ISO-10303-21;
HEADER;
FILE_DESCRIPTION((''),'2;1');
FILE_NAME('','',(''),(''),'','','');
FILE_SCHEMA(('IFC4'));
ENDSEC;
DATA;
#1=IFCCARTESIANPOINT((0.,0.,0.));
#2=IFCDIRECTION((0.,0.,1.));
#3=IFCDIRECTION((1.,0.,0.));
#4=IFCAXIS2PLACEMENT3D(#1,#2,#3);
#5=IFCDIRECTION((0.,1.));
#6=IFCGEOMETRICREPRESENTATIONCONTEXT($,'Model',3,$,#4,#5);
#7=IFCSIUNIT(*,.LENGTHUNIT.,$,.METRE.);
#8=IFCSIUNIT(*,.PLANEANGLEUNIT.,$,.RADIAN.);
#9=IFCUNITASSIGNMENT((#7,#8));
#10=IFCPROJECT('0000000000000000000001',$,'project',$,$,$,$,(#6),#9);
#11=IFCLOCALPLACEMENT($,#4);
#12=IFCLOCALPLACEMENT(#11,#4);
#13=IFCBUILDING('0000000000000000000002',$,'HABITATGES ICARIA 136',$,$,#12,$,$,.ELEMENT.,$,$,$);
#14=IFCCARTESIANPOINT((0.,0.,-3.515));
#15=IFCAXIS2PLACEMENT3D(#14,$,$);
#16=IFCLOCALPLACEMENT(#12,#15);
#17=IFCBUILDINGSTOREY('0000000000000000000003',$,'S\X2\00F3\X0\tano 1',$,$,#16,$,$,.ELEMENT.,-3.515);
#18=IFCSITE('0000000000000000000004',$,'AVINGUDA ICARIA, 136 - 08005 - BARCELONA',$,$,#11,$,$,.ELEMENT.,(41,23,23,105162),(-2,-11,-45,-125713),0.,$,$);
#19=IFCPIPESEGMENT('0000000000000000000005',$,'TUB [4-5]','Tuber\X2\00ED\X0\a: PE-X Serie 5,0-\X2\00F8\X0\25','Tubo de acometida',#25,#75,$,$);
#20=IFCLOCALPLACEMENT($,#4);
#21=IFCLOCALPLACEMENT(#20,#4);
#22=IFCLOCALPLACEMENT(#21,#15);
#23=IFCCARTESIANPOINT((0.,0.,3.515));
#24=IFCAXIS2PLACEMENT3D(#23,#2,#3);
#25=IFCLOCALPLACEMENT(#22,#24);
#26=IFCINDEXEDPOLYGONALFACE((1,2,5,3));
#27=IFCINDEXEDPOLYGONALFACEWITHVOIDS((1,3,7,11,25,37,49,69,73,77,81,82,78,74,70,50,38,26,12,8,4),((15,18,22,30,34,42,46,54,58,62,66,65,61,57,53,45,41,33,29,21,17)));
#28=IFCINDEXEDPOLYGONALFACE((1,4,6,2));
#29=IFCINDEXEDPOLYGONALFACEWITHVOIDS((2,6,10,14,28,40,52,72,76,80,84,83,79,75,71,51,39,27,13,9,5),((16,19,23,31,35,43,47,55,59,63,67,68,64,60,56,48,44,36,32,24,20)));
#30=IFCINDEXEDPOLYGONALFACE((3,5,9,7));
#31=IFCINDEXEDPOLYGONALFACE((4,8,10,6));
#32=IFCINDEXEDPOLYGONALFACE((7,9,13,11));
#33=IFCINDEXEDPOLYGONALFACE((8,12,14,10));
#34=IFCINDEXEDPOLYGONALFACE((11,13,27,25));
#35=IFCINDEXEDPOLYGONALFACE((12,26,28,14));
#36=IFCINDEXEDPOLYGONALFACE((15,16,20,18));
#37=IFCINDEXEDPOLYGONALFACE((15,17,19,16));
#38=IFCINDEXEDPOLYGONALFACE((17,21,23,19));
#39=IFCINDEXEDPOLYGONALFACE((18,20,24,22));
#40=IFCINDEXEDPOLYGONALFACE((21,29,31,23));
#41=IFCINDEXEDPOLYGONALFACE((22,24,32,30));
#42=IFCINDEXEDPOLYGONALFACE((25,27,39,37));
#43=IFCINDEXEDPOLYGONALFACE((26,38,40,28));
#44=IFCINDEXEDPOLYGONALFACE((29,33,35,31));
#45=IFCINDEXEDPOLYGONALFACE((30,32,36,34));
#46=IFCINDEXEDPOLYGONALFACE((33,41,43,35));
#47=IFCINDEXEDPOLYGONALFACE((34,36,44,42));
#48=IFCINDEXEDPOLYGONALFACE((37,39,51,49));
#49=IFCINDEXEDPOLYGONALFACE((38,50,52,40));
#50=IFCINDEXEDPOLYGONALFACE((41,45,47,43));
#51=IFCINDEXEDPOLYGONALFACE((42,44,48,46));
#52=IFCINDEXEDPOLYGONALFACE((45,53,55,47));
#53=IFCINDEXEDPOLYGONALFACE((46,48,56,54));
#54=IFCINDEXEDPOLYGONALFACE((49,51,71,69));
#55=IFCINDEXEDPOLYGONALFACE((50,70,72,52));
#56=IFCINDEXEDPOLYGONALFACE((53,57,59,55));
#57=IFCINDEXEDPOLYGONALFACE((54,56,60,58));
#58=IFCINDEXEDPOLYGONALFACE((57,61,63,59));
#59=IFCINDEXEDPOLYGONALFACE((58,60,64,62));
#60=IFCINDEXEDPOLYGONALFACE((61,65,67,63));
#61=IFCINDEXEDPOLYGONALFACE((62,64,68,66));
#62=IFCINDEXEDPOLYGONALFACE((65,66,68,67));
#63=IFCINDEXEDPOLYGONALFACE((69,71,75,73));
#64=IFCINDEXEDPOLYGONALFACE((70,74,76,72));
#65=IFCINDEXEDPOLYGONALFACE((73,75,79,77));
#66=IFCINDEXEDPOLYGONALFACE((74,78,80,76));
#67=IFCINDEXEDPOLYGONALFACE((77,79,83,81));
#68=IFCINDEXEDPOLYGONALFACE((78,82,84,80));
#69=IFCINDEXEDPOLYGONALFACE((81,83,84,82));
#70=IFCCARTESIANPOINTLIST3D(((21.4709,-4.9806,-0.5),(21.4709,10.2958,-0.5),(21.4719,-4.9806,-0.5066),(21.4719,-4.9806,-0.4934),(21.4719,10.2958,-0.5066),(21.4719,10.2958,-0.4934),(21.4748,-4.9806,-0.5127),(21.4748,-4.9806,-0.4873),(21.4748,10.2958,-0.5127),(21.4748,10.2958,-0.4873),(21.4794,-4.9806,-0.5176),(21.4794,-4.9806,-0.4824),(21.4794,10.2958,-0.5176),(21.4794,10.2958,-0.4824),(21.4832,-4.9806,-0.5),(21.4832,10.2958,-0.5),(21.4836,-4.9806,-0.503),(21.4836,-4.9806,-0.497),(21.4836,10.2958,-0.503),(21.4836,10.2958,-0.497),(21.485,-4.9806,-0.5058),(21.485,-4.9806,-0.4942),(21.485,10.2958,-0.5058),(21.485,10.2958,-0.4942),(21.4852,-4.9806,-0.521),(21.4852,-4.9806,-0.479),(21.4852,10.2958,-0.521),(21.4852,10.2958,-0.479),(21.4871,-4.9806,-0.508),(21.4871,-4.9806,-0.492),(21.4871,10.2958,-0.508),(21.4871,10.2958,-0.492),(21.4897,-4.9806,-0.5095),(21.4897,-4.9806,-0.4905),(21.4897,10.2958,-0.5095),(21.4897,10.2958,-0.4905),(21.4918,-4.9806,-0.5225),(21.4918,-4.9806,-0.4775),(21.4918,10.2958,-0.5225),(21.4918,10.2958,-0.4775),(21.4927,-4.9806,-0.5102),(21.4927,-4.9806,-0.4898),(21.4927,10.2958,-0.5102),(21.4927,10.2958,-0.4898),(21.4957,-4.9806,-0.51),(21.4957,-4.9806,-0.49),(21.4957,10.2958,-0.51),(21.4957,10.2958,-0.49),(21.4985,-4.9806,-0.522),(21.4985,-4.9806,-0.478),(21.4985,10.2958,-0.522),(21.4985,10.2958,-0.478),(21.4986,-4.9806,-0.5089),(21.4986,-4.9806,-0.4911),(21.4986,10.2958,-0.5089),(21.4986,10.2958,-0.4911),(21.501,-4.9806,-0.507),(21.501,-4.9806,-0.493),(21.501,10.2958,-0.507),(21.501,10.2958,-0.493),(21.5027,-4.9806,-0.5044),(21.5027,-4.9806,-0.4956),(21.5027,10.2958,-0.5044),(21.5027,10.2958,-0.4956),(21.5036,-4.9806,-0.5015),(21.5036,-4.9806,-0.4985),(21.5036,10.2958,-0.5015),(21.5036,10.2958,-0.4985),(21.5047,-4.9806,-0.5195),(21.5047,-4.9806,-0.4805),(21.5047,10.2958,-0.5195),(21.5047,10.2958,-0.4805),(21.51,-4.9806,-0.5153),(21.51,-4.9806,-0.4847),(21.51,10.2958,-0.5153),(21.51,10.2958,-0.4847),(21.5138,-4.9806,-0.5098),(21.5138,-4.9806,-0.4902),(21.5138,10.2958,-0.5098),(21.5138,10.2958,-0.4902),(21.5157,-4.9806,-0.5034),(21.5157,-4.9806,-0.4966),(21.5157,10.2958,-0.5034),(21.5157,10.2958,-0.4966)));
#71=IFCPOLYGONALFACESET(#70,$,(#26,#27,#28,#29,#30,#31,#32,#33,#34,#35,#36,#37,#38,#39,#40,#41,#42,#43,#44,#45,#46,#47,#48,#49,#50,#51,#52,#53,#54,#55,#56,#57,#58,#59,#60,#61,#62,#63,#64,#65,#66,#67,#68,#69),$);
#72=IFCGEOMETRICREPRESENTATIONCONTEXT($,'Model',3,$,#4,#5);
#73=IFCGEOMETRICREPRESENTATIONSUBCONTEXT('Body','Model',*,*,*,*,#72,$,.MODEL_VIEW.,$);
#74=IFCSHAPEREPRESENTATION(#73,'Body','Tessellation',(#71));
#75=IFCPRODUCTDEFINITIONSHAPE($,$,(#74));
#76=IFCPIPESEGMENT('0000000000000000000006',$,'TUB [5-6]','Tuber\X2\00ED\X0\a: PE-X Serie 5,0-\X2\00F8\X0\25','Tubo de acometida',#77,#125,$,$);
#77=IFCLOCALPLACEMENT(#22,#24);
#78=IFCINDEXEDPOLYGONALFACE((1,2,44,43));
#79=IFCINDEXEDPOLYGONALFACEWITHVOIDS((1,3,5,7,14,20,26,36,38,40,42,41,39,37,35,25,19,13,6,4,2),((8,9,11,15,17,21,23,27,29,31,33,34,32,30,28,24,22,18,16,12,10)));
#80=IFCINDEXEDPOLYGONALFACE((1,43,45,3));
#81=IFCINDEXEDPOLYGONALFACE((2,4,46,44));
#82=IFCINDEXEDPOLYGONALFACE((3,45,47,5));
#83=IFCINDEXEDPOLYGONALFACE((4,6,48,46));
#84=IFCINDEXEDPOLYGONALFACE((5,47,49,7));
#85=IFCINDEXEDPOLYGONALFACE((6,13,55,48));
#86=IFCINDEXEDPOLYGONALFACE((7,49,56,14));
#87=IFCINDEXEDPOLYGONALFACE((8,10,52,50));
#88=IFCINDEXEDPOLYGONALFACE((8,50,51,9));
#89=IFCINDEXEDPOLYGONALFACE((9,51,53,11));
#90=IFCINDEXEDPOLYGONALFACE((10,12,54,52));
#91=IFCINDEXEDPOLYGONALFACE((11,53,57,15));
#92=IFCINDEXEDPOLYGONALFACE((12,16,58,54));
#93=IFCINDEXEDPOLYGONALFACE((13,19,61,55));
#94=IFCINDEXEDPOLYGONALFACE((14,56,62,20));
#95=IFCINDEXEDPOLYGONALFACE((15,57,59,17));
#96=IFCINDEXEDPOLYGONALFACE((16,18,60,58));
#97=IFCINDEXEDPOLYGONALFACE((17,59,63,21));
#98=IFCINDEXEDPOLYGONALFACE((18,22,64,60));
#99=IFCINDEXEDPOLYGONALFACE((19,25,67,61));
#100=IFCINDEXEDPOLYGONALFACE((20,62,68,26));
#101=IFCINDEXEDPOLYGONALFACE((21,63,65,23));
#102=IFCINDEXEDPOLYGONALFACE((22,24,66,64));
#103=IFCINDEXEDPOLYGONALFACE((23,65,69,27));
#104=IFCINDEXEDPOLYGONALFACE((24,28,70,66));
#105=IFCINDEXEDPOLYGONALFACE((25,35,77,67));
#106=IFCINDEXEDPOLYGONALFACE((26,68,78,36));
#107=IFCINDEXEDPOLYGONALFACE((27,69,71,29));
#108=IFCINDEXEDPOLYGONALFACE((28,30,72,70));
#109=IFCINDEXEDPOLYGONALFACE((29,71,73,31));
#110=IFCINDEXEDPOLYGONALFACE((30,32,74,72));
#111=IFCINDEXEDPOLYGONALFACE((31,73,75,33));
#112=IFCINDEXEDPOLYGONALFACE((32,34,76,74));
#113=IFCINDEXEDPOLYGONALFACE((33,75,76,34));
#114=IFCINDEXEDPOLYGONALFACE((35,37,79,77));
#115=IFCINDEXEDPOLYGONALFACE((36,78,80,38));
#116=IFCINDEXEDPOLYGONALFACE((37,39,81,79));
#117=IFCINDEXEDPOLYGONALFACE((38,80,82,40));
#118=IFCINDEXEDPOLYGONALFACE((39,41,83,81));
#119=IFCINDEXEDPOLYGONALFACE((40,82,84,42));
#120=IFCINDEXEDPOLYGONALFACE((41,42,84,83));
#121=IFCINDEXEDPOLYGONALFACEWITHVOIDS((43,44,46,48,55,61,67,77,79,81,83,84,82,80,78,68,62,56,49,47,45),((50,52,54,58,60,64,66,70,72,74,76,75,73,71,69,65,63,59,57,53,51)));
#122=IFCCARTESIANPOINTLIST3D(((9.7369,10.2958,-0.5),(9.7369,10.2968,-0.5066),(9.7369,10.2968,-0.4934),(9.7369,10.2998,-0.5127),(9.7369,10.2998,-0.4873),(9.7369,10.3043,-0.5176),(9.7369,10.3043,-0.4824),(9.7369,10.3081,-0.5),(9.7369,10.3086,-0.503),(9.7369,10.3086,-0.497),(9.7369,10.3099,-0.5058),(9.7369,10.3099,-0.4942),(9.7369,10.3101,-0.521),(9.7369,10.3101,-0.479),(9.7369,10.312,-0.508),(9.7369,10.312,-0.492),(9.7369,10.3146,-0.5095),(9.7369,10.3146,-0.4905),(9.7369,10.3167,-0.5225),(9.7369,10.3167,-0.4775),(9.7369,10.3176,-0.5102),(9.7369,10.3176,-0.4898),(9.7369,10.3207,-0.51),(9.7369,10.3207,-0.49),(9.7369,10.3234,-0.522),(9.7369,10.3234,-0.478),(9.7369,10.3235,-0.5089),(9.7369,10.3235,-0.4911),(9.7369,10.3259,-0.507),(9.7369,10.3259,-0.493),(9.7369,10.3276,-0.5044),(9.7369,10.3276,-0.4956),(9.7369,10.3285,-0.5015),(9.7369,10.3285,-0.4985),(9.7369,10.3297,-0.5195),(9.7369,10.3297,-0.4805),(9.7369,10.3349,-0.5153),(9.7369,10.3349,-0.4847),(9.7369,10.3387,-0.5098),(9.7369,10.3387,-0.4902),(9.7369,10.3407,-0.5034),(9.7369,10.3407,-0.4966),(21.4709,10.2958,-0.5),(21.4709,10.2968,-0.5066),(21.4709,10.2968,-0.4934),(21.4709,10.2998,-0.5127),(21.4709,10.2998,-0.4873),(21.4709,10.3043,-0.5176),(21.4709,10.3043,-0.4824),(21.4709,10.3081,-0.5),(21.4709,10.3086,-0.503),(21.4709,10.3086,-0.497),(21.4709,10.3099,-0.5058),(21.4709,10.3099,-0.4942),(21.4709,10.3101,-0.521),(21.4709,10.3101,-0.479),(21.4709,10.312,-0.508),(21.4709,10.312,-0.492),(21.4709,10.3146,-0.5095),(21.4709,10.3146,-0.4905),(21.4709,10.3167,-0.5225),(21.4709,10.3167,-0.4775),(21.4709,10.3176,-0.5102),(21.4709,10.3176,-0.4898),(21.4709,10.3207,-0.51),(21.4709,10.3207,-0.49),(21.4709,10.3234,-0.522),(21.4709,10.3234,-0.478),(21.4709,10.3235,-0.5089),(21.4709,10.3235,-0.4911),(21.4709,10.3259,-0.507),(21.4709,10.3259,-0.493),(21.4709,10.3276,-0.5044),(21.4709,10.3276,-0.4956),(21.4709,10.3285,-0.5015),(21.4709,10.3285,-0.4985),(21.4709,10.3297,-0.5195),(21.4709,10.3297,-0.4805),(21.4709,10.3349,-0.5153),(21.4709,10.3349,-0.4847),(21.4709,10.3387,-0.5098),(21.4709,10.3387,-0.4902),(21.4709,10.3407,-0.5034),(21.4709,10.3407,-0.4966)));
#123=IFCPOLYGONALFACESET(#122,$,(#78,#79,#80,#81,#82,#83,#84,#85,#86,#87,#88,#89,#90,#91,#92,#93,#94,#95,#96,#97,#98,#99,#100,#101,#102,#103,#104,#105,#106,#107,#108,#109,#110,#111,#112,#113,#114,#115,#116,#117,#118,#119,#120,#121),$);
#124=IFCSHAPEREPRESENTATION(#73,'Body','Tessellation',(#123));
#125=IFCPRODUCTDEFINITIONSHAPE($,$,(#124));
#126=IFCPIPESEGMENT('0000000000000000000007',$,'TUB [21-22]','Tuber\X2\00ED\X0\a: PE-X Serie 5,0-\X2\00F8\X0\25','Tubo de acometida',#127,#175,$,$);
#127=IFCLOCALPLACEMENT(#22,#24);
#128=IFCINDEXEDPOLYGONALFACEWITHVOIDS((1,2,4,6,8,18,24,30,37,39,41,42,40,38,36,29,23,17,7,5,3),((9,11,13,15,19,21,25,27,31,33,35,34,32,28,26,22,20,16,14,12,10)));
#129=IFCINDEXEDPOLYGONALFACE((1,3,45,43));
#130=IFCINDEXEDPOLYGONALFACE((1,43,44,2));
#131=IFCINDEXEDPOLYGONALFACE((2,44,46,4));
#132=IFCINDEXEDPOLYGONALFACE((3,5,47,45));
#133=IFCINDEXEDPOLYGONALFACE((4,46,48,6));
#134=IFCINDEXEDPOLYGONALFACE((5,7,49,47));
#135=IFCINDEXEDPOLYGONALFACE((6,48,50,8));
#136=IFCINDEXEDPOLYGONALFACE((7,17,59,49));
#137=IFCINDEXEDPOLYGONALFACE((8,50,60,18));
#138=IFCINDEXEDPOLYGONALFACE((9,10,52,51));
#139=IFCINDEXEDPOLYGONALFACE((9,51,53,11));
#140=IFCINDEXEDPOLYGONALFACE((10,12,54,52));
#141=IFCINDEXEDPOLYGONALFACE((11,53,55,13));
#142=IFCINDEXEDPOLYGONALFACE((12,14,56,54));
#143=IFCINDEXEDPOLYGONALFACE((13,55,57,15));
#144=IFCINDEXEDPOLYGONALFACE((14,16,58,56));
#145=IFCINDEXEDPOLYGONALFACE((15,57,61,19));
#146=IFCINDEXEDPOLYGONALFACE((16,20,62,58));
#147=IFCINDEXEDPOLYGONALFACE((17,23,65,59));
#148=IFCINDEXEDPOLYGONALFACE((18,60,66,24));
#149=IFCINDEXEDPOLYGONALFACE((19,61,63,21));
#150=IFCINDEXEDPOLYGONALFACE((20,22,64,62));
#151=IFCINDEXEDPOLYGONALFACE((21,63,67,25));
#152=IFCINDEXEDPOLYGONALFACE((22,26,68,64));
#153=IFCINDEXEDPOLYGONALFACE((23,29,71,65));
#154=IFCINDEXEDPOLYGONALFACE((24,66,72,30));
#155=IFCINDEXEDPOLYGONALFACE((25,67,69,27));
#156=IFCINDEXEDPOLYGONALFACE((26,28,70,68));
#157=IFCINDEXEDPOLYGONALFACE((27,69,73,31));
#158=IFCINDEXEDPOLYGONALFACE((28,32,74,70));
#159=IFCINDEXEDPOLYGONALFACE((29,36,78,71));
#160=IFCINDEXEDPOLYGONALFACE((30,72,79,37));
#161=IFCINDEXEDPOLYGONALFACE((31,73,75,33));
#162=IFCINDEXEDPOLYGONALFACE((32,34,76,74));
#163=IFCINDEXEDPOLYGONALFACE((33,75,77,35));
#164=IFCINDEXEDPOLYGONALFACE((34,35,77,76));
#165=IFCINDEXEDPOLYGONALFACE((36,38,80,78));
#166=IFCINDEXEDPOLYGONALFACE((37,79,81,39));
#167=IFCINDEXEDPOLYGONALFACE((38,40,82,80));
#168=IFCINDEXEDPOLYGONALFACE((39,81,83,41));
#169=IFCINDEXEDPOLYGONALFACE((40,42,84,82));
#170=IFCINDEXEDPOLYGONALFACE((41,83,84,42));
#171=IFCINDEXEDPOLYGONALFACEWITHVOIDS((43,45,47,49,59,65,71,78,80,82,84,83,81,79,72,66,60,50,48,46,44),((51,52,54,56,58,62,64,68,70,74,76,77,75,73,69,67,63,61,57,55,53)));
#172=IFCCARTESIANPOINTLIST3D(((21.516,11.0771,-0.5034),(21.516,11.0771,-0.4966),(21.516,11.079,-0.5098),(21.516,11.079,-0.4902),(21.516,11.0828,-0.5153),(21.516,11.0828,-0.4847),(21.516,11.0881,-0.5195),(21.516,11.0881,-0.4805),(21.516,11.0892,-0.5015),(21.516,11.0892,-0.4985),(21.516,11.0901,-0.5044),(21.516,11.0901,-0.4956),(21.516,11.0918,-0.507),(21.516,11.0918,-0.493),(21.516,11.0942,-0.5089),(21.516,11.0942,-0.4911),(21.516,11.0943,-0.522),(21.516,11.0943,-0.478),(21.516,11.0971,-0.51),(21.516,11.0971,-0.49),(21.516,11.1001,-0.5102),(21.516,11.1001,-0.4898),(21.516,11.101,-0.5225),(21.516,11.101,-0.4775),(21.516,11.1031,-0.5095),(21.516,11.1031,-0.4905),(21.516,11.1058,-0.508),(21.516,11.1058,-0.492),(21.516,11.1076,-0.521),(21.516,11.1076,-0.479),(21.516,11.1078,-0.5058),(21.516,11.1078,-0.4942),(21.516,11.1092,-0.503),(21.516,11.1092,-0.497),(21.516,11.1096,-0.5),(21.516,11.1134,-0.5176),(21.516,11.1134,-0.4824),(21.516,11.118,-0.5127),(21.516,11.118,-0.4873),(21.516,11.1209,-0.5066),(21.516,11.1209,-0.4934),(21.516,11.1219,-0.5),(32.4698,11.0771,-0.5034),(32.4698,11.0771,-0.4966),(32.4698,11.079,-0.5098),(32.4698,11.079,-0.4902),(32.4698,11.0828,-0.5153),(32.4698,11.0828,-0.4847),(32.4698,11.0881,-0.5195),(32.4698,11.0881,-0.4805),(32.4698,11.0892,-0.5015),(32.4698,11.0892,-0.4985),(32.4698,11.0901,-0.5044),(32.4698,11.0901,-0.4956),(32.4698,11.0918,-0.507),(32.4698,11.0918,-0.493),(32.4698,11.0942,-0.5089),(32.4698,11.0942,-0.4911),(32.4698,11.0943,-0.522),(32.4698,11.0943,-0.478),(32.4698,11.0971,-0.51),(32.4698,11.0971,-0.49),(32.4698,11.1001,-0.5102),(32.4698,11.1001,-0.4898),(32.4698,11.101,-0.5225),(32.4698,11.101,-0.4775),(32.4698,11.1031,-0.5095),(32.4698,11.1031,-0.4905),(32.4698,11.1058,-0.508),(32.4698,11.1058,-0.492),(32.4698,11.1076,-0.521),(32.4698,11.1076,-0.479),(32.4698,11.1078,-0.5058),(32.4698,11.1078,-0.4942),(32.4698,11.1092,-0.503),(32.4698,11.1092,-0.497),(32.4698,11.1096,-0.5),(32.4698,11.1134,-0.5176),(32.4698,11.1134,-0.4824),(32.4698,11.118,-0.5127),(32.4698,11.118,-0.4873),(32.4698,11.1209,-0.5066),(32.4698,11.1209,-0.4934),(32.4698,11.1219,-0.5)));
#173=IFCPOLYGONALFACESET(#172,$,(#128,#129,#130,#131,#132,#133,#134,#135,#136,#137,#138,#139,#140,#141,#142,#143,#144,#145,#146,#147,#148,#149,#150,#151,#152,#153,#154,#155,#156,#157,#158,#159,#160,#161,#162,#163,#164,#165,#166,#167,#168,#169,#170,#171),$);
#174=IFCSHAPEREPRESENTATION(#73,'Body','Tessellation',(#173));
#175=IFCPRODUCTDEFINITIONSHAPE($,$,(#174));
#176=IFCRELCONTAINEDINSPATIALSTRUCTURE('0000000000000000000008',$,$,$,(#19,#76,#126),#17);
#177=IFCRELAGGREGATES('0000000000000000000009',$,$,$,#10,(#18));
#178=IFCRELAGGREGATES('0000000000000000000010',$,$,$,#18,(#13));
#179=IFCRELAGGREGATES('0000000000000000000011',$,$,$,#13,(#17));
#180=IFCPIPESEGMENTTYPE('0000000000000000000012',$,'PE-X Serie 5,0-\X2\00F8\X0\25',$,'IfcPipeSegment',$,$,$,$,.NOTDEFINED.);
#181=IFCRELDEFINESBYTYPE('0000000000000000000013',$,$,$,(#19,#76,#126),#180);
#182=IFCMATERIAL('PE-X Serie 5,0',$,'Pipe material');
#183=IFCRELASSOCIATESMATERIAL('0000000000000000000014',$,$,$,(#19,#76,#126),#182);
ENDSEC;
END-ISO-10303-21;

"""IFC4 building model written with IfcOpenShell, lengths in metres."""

from ifc_helpers import new_model, si_unit, direction, frame, origin_with_axes, origin_2d_with_axis, place, context, subcontext, project, spatial, hollow_circle, extrude, material, type_object, element, save


model = new_model("IFC4")

# Units and contexts
model_context_1 = context("Model", 3, world=origin_with_axes(), true_north=direction((0.0, 1.0)))
model_context_2 = context("Model", 3, world=origin_with_axes(), true_north=direction((0.0, 1.0)))
body_context_1 = subcontext(model_context_2, "Body", "Model", "MODEL_VIEW")
ifc_project = project(units=[si_unit("LENGTHUNIT", "METRE"), si_unit("PLANEANGLEUNIT", "RADIAN")], contexts=[model_context_1])

# Site, building, storey
site_placement = place(None, origin_with_axes())
site = spatial("IfcSite", under=ifc_project, at=site_placement, Name="AVINGUDA ICARIA, 136 - 08005 - BARCELONA", CompositionType="ELEMENT", RefLatitude=(41, 23, 23, 105162), RefLongitude=(-2, -11, -45, -125713), RefElevation=0.0)
building_placement = place(site_placement, origin_with_axes())
building = spatial("IfcBuilding", under=site, at=building_placement, Name="HABITATGES ICARIA 136", CompositionType="ELEMENT")
storey_placement = place(building_placement, frame((0.0, 0.0, -3.515)))
storey = spatial("IfcBuildingStorey", under=building, at=storey_placement, Name="Sótano 1", CompositionType="ELEMENT", Elevation=-3.515)

# Pipe segments
ifc_material_1 = material(Name="PE-X Serie 5,0", Category="Pipe material")
pipe_segment_type = type_object("IfcPipeSegmentType", Name="PE-X Serie 5,0-ø25", ApplicableOccurrence="IfcPipeSegment", PredefinedType="NOTDEFINED")
placement_1 = place(None, origin_with_axes())
placement_2 = place(placement_1, origin_with_axes())
placement_3 = place(placement_2, frame((0.0, 0.0, -3.515)))
pipe_segment_1_placement = place(placement_3, frame((0.0, 0.0, 3.515), z_axis=(0.0, 0.0, 1.0), x_axis=(1.0, 0.0, 0.0)))
element("IfcPipeSegment", 1, at=pipe_segment_1_placement, inside=storey, type_object=pipe_segment_type, material=ifc_material_1, Name="TUB [4-5]", Description="Tubería: PE-X Serie 5,0-ø25", ObjectType="Tubo de acometida", context=body_context_1, shape_type="SweptSolid", body=[
    extrude(hollow_circle(Radius=0.0226, WallThickness=0.0123, at=origin_2d_with_axis()), frame((21.4934, -4.9806, -0.5), z_axis=(0.0, 1.0, 0.0), x_axis=(-1.0, 0.0, 0.0)), (0.0, 0.0, 1.0), 15.2765),
])
pipe_segment_2_placement = place(placement_3, frame((0.0, 0.0, 3.515), z_axis=(0.0, 0.0, 1.0), x_axis=(1.0, 0.0, 0.0)))
element("IfcPipeSegment", 2, at=pipe_segment_2_placement, inside=storey, type_object=pipe_segment_type, material=ifc_material_1, Name="TUB [5-6]", Description="Tubería: PE-X Serie 5,0-ø25", ObjectType="Tubo de acometida", context=body_context_1, shape_type="SweptSolid", body=[
    extrude(hollow_circle(Radius=0.0226, WallThickness=0.0123, at=origin_2d_with_axis()), frame((21.4709, 10.3184, -0.5), z_axis=(-1.0, 0.0, 0.0), x_axis=(0.0, -1.0, 0.0)), (0.0, 0.0, 1.0), 11.734),
])
pipe_segment_3_placement = place(placement_3, frame((0.0, 0.0, 3.515), z_axis=(0.0, 0.0, 1.0), x_axis=(1.0, 0.0, 0.0)))
element("IfcPipeSegment", 3, at=pipe_segment_3_placement, inside=storey, type_object=pipe_segment_type, material=ifc_material_1, Name="TUB [21-22]", Description="Tubería: PE-X Serie 5,0-ø25", ObjectType="Tubo de acometida", context=body_context_1, shape_type="SweptSolid", body=[
    extrude(hollow_circle(Radius=0.0226, WallThickness=0.0123, at=origin_2d_with_axis()), frame((21.516, 11.0994, -0.5), z_axis=(1.0, 0.0, 0.0), x_axis=(0.0, 1.0, 0.0)), (0.0, 0.0, 1.0), 10.9538),
])

save(model, "model.ifc")
